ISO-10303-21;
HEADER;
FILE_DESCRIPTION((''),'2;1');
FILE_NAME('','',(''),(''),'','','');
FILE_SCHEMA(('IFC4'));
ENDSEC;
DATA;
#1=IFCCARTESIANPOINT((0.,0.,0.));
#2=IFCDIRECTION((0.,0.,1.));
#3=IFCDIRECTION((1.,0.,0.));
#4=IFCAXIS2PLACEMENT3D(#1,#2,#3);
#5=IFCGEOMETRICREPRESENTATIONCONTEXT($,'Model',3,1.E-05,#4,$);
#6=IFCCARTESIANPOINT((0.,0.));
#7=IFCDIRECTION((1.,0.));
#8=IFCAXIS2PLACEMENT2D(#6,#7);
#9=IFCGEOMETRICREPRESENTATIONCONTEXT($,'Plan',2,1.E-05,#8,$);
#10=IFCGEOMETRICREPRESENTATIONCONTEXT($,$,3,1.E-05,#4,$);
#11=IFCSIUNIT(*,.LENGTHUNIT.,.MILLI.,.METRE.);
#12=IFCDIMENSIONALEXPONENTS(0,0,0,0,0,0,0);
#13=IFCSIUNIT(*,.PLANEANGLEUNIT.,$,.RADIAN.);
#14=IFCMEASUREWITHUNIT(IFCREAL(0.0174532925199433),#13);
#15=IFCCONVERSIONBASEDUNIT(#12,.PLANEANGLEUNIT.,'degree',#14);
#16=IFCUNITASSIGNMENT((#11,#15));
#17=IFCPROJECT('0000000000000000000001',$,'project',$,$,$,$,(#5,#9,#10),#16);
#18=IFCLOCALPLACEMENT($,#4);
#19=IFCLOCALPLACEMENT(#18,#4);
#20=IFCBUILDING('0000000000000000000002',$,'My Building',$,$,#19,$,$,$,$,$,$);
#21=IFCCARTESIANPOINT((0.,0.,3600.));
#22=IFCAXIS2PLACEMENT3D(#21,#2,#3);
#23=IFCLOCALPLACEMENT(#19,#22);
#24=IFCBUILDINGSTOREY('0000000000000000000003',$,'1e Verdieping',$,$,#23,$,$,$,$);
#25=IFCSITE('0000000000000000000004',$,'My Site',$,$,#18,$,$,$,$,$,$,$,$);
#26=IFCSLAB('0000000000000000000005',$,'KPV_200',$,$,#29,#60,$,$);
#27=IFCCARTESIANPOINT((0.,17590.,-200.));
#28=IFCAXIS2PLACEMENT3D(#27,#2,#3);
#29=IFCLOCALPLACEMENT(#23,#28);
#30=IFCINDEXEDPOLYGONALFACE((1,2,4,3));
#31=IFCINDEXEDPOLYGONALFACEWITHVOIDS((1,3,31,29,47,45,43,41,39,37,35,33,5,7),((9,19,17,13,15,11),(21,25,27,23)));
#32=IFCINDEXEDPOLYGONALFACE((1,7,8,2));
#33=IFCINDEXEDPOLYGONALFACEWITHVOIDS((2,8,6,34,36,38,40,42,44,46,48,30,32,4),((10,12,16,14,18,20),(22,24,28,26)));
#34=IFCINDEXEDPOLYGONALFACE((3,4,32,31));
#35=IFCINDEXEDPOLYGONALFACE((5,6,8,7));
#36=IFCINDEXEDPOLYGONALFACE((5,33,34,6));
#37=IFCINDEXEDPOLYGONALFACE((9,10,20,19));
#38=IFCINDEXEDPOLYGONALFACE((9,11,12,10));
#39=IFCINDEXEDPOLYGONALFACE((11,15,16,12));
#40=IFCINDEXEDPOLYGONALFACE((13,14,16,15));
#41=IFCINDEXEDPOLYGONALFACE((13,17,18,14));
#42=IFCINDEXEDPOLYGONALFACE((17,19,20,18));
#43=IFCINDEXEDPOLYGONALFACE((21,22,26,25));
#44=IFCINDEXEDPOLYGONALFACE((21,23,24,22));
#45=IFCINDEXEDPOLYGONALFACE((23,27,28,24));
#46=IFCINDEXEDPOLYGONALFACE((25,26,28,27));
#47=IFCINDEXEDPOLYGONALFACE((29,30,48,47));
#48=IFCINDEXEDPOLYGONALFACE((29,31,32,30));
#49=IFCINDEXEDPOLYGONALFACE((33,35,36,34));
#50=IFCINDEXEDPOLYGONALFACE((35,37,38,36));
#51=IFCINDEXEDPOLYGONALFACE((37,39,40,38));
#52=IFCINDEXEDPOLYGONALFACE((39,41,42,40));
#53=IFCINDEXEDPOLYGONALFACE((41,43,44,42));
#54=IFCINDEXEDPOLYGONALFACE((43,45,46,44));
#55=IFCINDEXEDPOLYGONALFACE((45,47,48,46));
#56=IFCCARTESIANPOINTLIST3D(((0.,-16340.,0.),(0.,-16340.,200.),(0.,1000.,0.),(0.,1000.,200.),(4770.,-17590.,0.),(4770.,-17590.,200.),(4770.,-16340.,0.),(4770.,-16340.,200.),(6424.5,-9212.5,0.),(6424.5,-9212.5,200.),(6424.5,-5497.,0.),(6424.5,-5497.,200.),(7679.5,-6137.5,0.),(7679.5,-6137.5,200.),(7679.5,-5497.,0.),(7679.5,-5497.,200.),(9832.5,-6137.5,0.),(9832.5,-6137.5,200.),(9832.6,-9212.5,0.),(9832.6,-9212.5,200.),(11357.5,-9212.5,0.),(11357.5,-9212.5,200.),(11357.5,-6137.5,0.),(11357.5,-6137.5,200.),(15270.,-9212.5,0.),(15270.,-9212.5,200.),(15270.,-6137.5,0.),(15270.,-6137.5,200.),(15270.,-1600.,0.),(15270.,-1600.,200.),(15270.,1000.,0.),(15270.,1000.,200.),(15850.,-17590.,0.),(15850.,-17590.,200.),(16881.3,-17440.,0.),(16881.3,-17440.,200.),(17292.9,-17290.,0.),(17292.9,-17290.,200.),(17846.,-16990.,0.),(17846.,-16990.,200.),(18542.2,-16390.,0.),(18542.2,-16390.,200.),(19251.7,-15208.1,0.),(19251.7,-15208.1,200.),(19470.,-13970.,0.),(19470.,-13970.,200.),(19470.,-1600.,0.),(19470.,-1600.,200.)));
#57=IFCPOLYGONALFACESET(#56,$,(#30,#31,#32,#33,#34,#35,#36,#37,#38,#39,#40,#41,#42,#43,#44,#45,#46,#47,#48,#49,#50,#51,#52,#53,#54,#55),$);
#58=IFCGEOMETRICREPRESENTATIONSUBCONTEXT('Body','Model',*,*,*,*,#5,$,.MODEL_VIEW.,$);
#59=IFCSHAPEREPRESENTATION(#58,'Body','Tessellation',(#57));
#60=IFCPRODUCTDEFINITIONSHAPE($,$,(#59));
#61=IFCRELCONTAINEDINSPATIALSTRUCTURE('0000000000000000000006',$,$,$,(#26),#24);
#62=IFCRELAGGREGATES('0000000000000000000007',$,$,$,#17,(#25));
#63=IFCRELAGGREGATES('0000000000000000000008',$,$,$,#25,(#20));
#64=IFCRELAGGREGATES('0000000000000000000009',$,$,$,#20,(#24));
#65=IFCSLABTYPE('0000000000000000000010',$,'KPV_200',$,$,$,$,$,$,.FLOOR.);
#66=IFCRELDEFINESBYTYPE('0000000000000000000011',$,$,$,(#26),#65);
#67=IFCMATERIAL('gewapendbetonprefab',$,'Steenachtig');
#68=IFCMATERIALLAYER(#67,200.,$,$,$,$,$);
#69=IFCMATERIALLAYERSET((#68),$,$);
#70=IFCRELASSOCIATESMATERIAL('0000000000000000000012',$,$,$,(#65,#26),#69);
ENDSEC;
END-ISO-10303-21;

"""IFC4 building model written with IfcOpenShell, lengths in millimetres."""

from ifc_helpers import new_model, entity, si_unit, converted_unit, frame, origin_with_axes, origin_2d_with_axis, place, context, subcontext, project, spatial, line, indexed_curve, outline, extrude, material, layer, layer_set, layer_usage, type_object, element, save


model = new_model("IFC4")

# Units and contexts
model_context = context("Model", 3, precision=1e-05, world=origin_with_axes())
plan_context = context("Plan", 2, precision=1e-05, world=origin_2d_with_axis())
context_of_model = context(None, 3, precision=1e-05, world=origin_with_axes())
body_context = subcontext(model_context, "Body", "Model", "MODEL_VIEW")
ifc_project = project(units=[si_unit("LENGTHUNIT", "METRE", prefix="MILLI"), converted_unit("PLANEANGLEUNIT", "degree", entity("IfcReal", 0.0174532925199433), si_unit("PLANEANGLEUNIT", "RADIAN"), dimensions=[0, 0, 0, 0, 0, 0, 0])], contexts=[model_context, plan_context, context_of_model])

# Site, building, storey
site_placement = place(None, origin_with_axes())
site = spatial("IfcSite", under=ifc_project, at=site_placement, Name="My Site")
building_placement = place(site_placement, origin_with_axes())
building = spatial("IfcBuilding", under=site, at=building_placement, Name="My Building")
storey_placement = place(building_placement, frame((0.0, 0.0, 3600.0), z_axis=(0.0, 0.0, 1.0), x_axis=(1.0, 0.0, 0.0)))
storey = spatial("IfcBuildingStorey", under=building, at=storey_placement, Name="1e Verdieping")

# Slab
ifc_material_1 = material(Name="gewapendbetonprefab", Category="Steenachtig")
ifc_layer = layer(ifc_material_1, 200.0)
ifc_layer_set = layer_set([ifc_layer])
ifc_layer_usage = layer_usage(ifc_layer_set, "AXIS3", "POSITIVE", 0.0)
slab_type = type_object("IfcSlabType", Name="KPV_200", PredefinedType="FLOOR", material=ifc_layer_set)
slab_placement = place(storey_placement, frame((0.0, 17590.0, -200.0), z_axis=(0.0, 0.0, 1.0), x_axis=(1.0, 0.0, 0.0)))
element("IfcSlab", 1, at=slab_placement, inside=storey, type_object=slab_type, material=ifc_layer_usage, Name="KPV_200", context=body_context, shape_type="SweptSolid", body=[
    extrude(outline(indexed_curve([(17846.0, -16990.0), (17292.9, -17290.0), (16881.3, -17440.0), (15850.0, -17590.0), (4770.0, -17590.0), (4770.0, -16340.0), (0.0, -16340.0), (0.0, 1000.0), (15270.0, 1000.0), (15270.0, -1600.0), (19470.0, -1600.0), (19470.0, -13970.0), (19251.7, -15208.1), (18542.2, -16390.0), (15270.0, -9212.5), (15270.0, -6137.5), (11357.5, -9212.5), (11357.5, -6137.5), (9832.5, -6137.5), (7679.5, -6137.5), (7679.5, -5497.0), (6424.5, -5497.0), (6424.5, -9212.5), (9832.6, -9212.5)], segments=[line(13, 14), line(14, 1), line(1, 2), line(2, 3), line(3, 4), line(4, 5), line(5, 6), line(6, 7), line(7, 8), line(8, 9), line(9, 10), line(10, 11), line(11, 12), line(12, 13)], self_intersect=False), holes=[indexed_curve([(17846.0, -16990.0), (17292.9, -17290.0), (16881.3, -17440.0), (15850.0, -17590.0), (4770.0, -17590.0), (4770.0, -16340.0), (0.0, -16340.0), (0.0, 1000.0), (15270.0, 1000.0), (15270.0, -1600.0), (19470.0, -1600.0), (19470.0, -13970.0), (19251.7, -15208.1), (18542.2, -16390.0), (15270.0, -9212.5), (15270.0, -6137.5), (11357.5, -9212.5), (11357.5, -6137.5), (9832.5, -6137.5), (7679.5, -6137.5), (7679.5, -5497.0), (6424.5, -5497.0), (6424.5, -9212.5), (9832.6, -9212.5)], segments=[line(23, 22), line(22, 21), line(21, 20), line(20, 19), line(19, 24), line(24, 23)], self_intersect=False), indexed_curve([(17846.0, -16990.0), (17292.9, -17290.0), (16881.3, -17440.0), (15850.0, -17590.0), (4770.0, -17590.0), (4770.0, -16340.0), (0.0, -16340.0), (0.0, 1000.0), (15270.0, 1000.0), (15270.0, -1600.0), (19470.0, -1600.0), (19470.0, -13970.0), (19251.7, -15208.1), (18542.2, -16390.0), (15270.0, -9212.5), (15270.0, -6137.5), (11357.5, -9212.5), (11357.5, -6137.5), (9832.5, -6137.5), (7679.5, -6137.5), (7679.5, -5497.0), (6424.5, -5497.0), (6424.5, -9212.5), (9832.6, -9212.5)], segments=[line(18, 17), line(17, 15), line(15, 16), line(16, 18)], self_intersect=False)]), None, (0.0, 0.0, 1.0), 200.0),
])

save(model, "model.ifc")
